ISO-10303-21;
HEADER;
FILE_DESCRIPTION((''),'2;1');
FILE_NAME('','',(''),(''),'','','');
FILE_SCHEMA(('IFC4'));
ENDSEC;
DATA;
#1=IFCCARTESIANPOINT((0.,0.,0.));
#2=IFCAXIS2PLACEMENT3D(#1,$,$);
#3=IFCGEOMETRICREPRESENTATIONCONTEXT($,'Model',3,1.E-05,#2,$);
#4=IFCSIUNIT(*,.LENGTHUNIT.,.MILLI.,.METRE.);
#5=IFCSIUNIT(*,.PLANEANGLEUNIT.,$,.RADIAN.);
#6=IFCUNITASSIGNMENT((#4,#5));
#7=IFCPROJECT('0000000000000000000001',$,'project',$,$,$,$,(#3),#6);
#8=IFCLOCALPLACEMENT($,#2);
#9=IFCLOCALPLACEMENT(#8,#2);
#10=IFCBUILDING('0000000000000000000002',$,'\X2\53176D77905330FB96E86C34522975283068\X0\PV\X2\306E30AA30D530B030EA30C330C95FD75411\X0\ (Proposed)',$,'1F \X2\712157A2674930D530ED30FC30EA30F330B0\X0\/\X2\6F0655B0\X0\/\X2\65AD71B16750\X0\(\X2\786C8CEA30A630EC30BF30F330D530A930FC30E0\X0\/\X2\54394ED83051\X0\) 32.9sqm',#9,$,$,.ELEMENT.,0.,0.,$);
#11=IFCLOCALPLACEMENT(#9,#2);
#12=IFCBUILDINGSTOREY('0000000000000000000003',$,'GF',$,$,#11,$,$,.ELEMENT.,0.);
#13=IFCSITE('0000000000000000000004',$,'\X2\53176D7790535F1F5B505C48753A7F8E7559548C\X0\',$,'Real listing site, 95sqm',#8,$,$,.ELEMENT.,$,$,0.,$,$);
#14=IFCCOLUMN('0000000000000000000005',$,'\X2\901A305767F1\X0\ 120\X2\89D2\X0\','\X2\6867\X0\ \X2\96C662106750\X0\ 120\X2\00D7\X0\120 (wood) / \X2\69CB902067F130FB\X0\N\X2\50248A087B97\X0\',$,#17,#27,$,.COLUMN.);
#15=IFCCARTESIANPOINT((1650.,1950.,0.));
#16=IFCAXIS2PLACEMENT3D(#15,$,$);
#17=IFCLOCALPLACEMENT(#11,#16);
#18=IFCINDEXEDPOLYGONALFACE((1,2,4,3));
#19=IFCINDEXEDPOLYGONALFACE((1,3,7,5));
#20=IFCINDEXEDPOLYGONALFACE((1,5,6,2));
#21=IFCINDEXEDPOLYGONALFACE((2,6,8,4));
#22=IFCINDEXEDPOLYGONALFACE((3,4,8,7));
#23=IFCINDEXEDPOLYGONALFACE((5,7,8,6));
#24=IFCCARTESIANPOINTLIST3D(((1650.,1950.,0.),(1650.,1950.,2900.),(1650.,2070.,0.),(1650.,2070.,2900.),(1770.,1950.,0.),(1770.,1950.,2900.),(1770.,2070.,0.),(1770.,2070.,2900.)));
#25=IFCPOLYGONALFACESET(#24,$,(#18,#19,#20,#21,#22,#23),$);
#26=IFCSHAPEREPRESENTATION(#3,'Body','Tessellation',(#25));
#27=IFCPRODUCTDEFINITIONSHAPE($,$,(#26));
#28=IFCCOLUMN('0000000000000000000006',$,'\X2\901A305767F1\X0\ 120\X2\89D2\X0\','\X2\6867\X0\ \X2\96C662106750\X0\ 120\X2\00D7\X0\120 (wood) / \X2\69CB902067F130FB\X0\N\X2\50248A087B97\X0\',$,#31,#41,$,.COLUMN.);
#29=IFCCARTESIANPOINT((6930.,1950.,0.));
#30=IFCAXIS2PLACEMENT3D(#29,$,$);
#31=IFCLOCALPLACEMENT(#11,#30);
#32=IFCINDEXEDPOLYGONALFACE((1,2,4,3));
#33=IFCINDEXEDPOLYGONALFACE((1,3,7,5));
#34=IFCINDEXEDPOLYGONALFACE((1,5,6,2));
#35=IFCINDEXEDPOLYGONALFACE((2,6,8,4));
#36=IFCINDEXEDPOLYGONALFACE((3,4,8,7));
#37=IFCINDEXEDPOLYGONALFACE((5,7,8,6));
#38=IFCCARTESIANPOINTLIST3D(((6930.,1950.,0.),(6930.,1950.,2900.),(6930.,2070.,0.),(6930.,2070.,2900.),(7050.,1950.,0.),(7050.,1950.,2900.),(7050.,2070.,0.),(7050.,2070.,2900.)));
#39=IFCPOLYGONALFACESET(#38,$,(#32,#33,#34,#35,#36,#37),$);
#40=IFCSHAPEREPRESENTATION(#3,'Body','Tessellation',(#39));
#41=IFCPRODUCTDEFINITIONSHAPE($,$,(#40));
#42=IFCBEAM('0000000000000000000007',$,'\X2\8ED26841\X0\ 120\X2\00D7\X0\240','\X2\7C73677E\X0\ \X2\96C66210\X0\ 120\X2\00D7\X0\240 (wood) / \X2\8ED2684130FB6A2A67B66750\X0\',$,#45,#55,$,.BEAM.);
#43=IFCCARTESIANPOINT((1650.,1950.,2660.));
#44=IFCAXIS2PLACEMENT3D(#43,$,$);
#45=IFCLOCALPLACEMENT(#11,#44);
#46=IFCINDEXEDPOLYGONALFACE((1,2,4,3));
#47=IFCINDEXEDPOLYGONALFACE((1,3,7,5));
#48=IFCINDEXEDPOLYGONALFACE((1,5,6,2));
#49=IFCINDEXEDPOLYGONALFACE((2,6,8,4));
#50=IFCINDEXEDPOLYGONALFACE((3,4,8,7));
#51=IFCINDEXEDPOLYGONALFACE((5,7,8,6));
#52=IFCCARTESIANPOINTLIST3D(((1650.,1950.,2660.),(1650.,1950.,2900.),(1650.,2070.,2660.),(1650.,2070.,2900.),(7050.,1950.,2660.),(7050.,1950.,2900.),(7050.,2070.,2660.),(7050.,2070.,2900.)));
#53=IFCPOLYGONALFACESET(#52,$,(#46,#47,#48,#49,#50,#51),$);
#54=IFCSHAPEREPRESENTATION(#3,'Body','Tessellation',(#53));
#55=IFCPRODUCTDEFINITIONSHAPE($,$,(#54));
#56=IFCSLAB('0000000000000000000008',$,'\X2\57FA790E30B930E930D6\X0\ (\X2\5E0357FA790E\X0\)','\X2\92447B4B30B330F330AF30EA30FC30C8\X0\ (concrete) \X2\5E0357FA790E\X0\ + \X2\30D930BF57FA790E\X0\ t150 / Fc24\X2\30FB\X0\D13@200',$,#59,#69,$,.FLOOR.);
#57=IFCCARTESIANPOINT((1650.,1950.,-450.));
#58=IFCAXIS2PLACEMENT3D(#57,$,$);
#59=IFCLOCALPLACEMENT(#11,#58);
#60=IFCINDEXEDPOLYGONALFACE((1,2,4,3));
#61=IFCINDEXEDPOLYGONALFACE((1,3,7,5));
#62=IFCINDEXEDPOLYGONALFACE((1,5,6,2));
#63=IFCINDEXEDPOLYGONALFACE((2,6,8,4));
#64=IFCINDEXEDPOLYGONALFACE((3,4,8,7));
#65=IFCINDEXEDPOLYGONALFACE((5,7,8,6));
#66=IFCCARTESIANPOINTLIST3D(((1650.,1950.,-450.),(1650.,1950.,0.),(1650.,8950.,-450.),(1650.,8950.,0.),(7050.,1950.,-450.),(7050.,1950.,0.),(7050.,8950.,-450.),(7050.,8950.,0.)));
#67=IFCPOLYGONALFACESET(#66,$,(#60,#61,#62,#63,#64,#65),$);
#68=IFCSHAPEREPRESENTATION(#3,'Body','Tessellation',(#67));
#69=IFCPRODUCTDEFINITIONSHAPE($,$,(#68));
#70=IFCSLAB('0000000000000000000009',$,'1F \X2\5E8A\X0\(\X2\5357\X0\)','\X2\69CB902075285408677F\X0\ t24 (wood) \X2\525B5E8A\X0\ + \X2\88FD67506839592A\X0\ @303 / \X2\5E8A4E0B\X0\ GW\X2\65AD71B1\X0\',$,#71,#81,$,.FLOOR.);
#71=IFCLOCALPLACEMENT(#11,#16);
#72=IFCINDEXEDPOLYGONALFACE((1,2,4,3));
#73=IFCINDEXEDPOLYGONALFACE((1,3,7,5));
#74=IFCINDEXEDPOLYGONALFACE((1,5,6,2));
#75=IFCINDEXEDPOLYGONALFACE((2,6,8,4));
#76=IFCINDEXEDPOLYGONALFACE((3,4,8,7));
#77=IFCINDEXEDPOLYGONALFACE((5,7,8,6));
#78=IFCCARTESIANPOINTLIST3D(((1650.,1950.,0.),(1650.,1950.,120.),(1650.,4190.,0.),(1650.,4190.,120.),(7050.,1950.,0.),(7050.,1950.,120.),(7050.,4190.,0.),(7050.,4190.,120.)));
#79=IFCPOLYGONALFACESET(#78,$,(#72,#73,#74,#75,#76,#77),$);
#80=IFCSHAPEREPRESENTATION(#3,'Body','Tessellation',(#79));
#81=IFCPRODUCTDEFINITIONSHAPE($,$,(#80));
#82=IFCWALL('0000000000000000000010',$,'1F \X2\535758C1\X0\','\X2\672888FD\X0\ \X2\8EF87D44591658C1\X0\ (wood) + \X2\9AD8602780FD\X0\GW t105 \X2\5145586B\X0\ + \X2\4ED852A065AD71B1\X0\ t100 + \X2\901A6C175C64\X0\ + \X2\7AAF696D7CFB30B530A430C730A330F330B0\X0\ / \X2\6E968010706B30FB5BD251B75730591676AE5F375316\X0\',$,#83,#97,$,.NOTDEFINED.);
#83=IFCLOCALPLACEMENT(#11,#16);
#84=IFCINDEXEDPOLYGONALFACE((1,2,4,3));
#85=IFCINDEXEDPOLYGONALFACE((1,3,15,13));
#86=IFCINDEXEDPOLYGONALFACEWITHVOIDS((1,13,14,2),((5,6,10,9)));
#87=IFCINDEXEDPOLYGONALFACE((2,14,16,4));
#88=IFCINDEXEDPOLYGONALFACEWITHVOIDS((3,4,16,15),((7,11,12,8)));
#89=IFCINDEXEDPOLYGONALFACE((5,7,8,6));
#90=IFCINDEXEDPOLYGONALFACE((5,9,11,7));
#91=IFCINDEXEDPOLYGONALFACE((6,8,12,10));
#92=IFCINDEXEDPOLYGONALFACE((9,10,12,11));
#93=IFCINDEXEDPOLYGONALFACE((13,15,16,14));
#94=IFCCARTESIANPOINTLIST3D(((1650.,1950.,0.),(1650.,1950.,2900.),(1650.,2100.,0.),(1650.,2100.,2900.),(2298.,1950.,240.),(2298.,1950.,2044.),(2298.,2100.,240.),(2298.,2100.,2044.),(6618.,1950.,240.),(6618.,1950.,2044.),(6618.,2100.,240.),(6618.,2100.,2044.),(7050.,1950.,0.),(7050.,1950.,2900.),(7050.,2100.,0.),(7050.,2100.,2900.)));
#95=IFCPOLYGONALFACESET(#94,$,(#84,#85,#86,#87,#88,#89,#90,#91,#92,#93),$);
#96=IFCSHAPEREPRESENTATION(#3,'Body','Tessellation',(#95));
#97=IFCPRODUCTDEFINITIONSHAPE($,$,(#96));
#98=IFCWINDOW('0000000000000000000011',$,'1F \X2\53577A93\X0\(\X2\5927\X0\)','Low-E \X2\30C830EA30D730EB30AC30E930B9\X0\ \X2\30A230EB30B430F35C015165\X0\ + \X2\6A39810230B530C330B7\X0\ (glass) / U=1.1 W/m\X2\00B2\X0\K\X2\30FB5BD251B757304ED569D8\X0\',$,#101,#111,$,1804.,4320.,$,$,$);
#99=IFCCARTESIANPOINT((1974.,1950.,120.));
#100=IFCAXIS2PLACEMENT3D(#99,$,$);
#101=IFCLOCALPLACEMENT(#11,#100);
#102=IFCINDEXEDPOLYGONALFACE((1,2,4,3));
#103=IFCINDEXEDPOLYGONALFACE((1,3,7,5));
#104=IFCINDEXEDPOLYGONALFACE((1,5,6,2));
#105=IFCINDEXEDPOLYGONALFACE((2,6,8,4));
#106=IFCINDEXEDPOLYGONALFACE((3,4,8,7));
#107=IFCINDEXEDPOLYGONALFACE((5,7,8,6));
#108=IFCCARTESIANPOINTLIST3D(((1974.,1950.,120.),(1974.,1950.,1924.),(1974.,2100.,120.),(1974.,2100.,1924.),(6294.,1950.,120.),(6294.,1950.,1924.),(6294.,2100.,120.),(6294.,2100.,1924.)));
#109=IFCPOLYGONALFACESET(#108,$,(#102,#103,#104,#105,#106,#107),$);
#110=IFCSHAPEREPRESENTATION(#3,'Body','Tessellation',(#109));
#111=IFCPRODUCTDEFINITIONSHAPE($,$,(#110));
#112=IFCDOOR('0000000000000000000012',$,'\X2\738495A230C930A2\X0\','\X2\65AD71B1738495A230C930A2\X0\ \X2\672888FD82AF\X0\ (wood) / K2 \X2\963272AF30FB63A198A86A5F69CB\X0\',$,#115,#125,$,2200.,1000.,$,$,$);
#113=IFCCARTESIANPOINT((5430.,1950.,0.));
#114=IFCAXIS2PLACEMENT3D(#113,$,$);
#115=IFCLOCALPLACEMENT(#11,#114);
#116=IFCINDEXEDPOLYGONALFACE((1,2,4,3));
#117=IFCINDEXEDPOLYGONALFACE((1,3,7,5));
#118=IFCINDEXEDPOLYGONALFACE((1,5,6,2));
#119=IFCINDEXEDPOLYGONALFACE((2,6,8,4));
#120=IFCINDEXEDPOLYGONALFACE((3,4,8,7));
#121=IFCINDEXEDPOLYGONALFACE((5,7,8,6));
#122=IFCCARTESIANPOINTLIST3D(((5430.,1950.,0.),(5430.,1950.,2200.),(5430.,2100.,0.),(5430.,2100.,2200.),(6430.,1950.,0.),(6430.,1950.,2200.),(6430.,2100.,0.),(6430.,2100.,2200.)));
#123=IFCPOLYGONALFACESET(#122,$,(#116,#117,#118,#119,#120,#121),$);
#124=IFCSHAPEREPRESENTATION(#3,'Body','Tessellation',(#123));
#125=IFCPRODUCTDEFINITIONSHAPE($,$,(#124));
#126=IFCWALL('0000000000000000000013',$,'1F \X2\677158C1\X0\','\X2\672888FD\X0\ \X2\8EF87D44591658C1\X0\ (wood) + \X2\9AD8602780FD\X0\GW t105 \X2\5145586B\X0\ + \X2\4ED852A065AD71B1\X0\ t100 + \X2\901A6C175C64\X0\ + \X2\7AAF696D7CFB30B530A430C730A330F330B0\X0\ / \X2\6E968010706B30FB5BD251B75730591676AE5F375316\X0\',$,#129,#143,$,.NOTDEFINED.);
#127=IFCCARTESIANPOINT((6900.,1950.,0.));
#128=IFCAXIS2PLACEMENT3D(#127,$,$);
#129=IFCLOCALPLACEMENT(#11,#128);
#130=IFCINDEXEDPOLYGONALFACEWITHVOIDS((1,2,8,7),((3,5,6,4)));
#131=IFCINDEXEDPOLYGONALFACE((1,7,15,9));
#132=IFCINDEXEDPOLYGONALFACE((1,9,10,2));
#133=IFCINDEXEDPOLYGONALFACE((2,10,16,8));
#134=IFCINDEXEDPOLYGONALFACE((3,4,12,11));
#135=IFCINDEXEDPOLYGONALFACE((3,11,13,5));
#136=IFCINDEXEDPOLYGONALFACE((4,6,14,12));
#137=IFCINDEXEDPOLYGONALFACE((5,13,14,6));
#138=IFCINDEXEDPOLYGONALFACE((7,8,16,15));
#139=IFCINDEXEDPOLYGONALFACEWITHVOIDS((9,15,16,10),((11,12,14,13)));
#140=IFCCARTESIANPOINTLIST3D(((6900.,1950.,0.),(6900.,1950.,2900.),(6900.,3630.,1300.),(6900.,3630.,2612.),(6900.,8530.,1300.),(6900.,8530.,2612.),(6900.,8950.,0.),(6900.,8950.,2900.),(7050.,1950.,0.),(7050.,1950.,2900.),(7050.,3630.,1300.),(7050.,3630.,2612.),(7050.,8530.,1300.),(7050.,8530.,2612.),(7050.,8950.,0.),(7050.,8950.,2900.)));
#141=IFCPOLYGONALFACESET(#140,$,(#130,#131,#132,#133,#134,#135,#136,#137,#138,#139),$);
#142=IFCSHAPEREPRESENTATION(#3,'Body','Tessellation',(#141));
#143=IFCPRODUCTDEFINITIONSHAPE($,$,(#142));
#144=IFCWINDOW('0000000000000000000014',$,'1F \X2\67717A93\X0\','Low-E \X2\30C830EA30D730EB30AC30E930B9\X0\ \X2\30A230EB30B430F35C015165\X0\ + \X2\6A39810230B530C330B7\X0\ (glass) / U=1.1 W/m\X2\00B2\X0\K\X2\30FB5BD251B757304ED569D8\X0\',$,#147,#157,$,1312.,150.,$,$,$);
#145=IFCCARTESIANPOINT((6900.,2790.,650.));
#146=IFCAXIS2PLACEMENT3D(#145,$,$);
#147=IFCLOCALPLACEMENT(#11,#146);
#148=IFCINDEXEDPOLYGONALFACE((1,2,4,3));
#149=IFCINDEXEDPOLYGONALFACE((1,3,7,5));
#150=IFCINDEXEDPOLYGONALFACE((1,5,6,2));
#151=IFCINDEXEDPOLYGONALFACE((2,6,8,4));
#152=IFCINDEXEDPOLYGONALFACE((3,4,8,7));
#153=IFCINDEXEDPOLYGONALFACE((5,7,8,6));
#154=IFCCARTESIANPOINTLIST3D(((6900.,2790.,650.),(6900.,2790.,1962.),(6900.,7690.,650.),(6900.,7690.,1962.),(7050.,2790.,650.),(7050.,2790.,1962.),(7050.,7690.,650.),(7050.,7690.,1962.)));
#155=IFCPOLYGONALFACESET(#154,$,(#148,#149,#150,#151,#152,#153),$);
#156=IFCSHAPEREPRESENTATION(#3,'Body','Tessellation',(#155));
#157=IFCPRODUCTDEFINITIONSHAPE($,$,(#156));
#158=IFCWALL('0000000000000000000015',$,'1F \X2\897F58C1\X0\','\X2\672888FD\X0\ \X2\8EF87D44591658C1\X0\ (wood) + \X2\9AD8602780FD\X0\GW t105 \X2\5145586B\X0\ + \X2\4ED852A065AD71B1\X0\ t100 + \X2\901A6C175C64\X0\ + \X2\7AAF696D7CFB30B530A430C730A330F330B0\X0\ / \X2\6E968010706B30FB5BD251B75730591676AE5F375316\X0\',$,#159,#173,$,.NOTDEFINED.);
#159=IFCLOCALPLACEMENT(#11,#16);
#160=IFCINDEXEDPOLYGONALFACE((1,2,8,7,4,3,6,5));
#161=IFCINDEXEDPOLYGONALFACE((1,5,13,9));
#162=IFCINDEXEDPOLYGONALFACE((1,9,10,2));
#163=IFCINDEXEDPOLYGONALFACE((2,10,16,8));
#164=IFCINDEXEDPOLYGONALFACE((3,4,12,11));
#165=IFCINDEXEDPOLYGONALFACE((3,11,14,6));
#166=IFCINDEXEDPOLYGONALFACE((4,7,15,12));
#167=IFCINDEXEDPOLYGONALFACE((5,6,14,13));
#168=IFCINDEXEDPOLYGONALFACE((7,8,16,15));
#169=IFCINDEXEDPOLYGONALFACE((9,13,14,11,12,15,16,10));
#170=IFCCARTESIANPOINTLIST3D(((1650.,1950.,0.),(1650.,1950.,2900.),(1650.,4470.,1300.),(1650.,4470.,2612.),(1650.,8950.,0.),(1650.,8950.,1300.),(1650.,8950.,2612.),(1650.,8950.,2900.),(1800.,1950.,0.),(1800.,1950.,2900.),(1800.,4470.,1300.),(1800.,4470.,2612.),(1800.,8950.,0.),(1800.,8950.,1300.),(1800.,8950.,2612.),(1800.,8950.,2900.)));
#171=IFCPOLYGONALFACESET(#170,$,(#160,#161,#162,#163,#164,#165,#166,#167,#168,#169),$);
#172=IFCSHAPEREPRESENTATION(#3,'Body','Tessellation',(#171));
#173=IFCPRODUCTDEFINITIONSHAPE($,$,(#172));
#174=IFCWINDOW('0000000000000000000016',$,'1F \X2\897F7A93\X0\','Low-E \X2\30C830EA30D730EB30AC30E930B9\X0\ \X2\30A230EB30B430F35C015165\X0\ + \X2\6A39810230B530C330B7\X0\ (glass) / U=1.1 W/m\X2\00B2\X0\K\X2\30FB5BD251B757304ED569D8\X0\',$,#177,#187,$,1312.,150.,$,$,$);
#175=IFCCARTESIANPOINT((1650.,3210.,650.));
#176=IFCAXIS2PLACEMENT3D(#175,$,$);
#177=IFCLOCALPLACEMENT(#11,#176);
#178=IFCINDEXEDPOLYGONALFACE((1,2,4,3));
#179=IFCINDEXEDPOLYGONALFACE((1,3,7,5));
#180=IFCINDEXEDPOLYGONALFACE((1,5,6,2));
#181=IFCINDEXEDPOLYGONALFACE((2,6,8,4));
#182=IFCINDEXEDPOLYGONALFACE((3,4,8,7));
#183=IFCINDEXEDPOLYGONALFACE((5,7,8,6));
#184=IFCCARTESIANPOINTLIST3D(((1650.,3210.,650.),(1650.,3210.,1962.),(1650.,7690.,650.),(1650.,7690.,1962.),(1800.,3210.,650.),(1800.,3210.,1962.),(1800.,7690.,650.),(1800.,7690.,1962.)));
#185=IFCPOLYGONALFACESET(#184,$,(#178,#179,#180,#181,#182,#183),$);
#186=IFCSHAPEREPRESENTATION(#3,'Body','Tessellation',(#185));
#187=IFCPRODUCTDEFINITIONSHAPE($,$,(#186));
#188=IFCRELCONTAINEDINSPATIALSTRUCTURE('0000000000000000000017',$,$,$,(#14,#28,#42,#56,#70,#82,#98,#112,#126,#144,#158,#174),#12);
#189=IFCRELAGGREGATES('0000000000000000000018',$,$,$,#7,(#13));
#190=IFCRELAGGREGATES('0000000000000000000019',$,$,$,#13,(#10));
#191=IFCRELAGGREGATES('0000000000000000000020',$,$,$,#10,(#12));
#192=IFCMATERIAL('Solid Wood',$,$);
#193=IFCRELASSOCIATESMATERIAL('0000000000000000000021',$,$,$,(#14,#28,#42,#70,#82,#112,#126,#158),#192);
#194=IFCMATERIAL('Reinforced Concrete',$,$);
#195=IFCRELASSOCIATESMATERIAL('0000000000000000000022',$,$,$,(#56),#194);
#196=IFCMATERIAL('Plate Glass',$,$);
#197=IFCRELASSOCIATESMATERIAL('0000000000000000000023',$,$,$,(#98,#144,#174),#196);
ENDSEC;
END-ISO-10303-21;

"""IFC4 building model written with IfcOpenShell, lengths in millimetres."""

from ifc_helpers import new_model, si_unit, frame, frame_2d, origin, place, context, project, spatial, rectangle, extrude, material, element, fill, save


model = new_model("IFC4")

# Units and contexts
model_context = context("Model", 3, precision=1e-05, world=origin())
ifc_project = project(units=[si_unit("LENGTHUNIT", "METRE", prefix="MILLI"), si_unit("PLANEANGLEUNIT", "RADIAN")], contexts=[model_context])

# Site, building, storey
site_placement = place(None, origin())
site = spatial("IfcSite", under=ifc_project, at=site_placement, Name="北海道弟子屈町美留和", ObjectType="Real listing site, 95sqm", CompositionType="ELEMENT", RefElevation=0.0)
building_placement = place(site_placement, origin())
building = spatial("IfcBuilding", under=site, at=building_placement, Name="北海道・雨水利用とPVのオフグリッド志向 (Proposed)", ObjectType="1F 無垢杉フローリング/漆喰/断熱材(硬質ウレタンフォーム/吹付け) 32.9sqm", CompositionType="ELEMENT", ElevationOfRefHeight=0.0, ElevationOfTerrain=0.0)
storey_placement = place(building_placement, origin())
storey = spatial("IfcBuildingStorey", under=building, at=storey_placement, Name="GF", CompositionType="ELEMENT", Elevation=0.0)

# Columns
ifc_material_1 = material(Name="Solid Wood")
column_1_placement = place(storey_placement, frame((1650.0, 1950.0, 0.0)))
element("IfcColumn", 1, at=column_1_placement, inside=storey, material=ifc_material_1, Name="通し柱 120角", Description="桧 集成材 120×120 (wood) / 構造柱・N値計算", PredefinedType="COLUMN", context=model_context, shape_type="SweptSolid", body=[
    extrude(rectangle(XDim=120.0, YDim=120.0, at=frame_2d((60.0, 60.0))), frame((1650.0, 1950.0, 0.0)), (0.0, 0.0, 1.0), 2900.0),
])
column_2_placement = place(storey_placement, frame((6930.0, 1950.0, 0.0)))
element("IfcColumn", 2, at=column_2_placement, inside=storey, material=ifc_material_1, Name="通し柱 120角", Description="桧 集成材 120×120 (wood) / 構造柱・N値計算", PredefinedType="COLUMN", context=model_context, shape_type="SweptSolid", body=[
    extrude(rectangle(XDim=120.0, YDim=120.0, at=frame_2d((60.0, 60.0))), frame((6930.0, 1950.0, 0.0)), (0.0, 0.0, 1.0), 2900.0),
])

# Beam
beam_1_placement = place(storey_placement, frame((1650.0, 1950.0, 2660.0)))
element("IfcBeam", 3, at=beam_1_placement, inside=storey, material=ifc_material_1, Name="軒桁 120×240", Description="米松 集成 120×240 (wood) / 軒桁・横架材", PredefinedType="BEAM", context=model_context, shape_type="SweptSolid", body=[
    extrude(rectangle(XDim=5400.0, YDim=120.0, at=frame_2d((2700.0, 60.0))), frame((1650.0, 1950.0, 2660.0)), (0.0, 0.0, 1.0), 240.0),
])

# Slabs
ifc_material_2 = material(Name="Reinforced Concrete")
slab_1_placement = place(storey_placement, frame((1650.0, 1950.0, -450.0)))
element("IfcSlab", 4, at=slab_1_placement, inside=storey, material=ifc_material_2, Name="基礎スラブ (布基礎)", Description="鉄筋コンクリート (concrete) 布基礎 + ベタ基礎 t150 / Fc24・D13@200", PredefinedType="FLOOR", context=model_context, shape_type="SweptSolid", body=[
    extrude(rectangle(XDim=5400.0, YDim=7000.0, at=frame_2d((2700.0, 3500.0))), frame((1650.0, 1950.0, -450.0)), (0.0, 0.0, 1.0), 450.0),
])
slab_2_placement = place(storey_placement, frame((1650.0, 1950.0, 0.0)))
element("IfcSlab", 5, at=slab_2_placement, inside=storey, material=ifc_material_1, Name="1F 床(南)", Description="構造用合板 t24 (wood) 剛床 + 製材根太 @303 / 床下 GW断熱", PredefinedType="FLOOR", context=model_context, shape_type="SweptSolid", body=[
    extrude(rectangle(XDim=5400.0, YDim=2240.0, at=frame_2d((2700.0, 1120.0))), frame((1650.0, 1950.0, 0.0)), (0.0, 0.0, 1.0), 120.0),
])

# Wall, openings, window, door
wall_1_placement = place(storey_placement, frame((1650.0, 1950.0, 0.0)))
wall_1 = element("IfcWall", 6, at=wall_1_placement, inside=storey, material=ifc_material_1, Name="1F 南壁", Description="木製 軸組外壁 (wood) + 高性能GW t105 充填 + 付加断熱 t100 + 通気層 + 窯業系サイディング / 準耐火・寒冷地外皮強化", PredefinedType="NOTDEFINED", context=model_context, shape_type="SweptSolid", body=[
    extrude(rectangle(XDim=5400.0, YDim=150.0, at=frame_2d((2700.0, 75.0))), frame((1650.0, 1950.0, 0.0)), (0.0, 0.0, 1.0), 2900.0),
])
opening_1_placement = place(storey_placement, frame((1974.0, 1950.0, 120.0)))
opening_1 = element("IfcOpeningElement", 7, at=opening_1_placement, cuts=wall_1, PredefinedType="NOTDEFINED", context=model_context, shape_type="SweptSolid", body=[
    extrude(rectangle(XDim=4320.0, YDim=150.0, at=frame_2d((2160.0, 75.0))), frame((1974.0, 1950.0, 120.0)), (0.0, 0.0, 1.0), 1804.0),
])
opening_2_placement = place(storey_placement, frame((5430.0, 1950.0, 0.0)))
opening_2 = element("IfcOpeningElement", 8, at=opening_2_placement, cuts=wall_1, PredefinedType="NOTDEFINED", context=model_context, shape_type="SweptSolid", body=[
    extrude(rectangle(XDim=1000.0, YDim=150.0, at=frame_2d((500.0, 75.0))), frame((5430.0, 1950.0, 0.0)), (0.0, 0.0, 1.0), 2200.0),
])
ifc_material_3 = material(Name="Plate Glass")
window_1_placement = place(storey_placement, frame((1974.0, 1950.0, 120.0)))
window_1 = element("IfcWindow", 9, at=window_1_placement, inside=storey, material=ifc_material_3, Name="1F 南窓(大)", Description="Low-E トリプルガラス アルゴン封入 + 樹脂サッシ (glass) / U=1.1 W/m²K・寒冷地仕様", OverallHeight=1804.0, OverallWidth=4320.0, context=model_context, shape_type="SweptSolid", body=[
    extrude(rectangle(XDim=4320.0, YDim=150.0, at=frame_2d((2160.0, 75.0))), frame((1974.0, 1950.0, 120.0)), (0.0, 0.0, 1.0), 1804.0),
])
fill(opening_1, window_1)
door_placement = place(storey_placement, frame((5430.0, 1950.0, 0.0)))
door = element("IfcDoor", 10, at=door_placement, inside=storey, material=ifc_material_1, Name="玄関ドア", Description="断熱玄関ドア 木製芯 (wood) / K2 防犯・採風機構", OverallHeight=2200.0, OverallWidth=1000.0, context=model_context, shape_type="SweptSolid", body=[
    extrude(rectangle(XDim=1000.0, YDim=150.0, at=frame_2d((500.0, 75.0))), frame((5430.0, 1950.0, 0.0)), (0.0, 0.0, 1.0), 2200.0),
])
fill(opening_2, door)

# Walls, openings, windows
wall_2_placement = place(storey_placement, frame((6900.0, 1950.0, 0.0)))
wall_2 = element("IfcWall", 11, at=wall_2_placement, inside=storey, material=ifc_material_1, Name="1F 東壁", Description="木製 軸組外壁 (wood) + 高性能GW t105 充填 + 付加断熱 t100 + 通気層 + 窯業系サイディング / 準耐火・寒冷地外皮強化", PredefinedType="NOTDEFINED", context=model_context, shape_type="SweptSolid", body=[
    extrude(rectangle(XDim=150.0, YDim=7000.0, at=frame_2d((75.0, 3500.0))), frame((6900.0, 1950.0, 0.0)), (0.0, 0.0, 1.0), 2900.0),
])
opening_3_placement = place(storey_placement, frame((6900.0, 2790.0, 650.0)))
opening_3 = element("IfcOpeningElement", 12, at=opening_3_placement, cuts=wall_2, PredefinedType="NOTDEFINED", context=model_context, shape_type="SweptSolid", body=[
    extrude(rectangle(XDim=150.0, YDim=4900.0, at=frame_2d((75.0, 2450.0))), frame((6900.0, 2790.0, 650.0)), (0.0, 0.0, 1.0), 1312.0),
])
window_2_placement = place(storey_placement, frame((6900.0, 2790.0, 650.0)))
window_2 = element("IfcWindow", 13, at=window_2_placement, inside=storey, material=ifc_material_3, Name="1F 東窓", Description="Low-E トリプルガラス アルゴン封入 + 樹脂サッシ (glass) / U=1.1 W/m²K・寒冷地仕様", OverallHeight=1312.0, OverallWidth=150.0, context=model_context, shape_type="SweptSolid", body=[
    extrude(rectangle(XDim=150.0, YDim=4900.0, at=frame_2d((75.0, 2450.0))), frame((6900.0, 2790.0, 650.0)), (0.0, 0.0, 1.0), 1312.0),
])
fill(opening_3, window_2)
wall_3_placement = place(storey_placement, frame((1650.0, 1950.0, 0.0)))
wall_3 = element("IfcWall", 14, at=wall_3_placement, inside=storey, material=ifc_material_1, Name="1F 西壁", Description="木製 軸組外壁 (wood) + 高性能GW t105 充填 + 付加断熱 t100 + 通気層 + 窯業系サイディング / 準耐火・寒冷地外皮強化", PredefinedType="NOTDEFINED", context=model_context, shape_type="SweptSolid", body=[
    extrude(rectangle(XDim=150.0, YDim=7000.0, at=frame_2d((75.0, 3500.0))), frame((1650.0, 1950.0, 0.0)), (0.0, 0.0, 1.0), 2900.0),
])
opening_4_placement = place(storey_placement, frame((1650.0, 3210.0, 650.0)))
opening_4 = element("IfcOpeningElement", 15, at=opening_4_placement, cuts=wall_3, PredefinedType="NOTDEFINED", context=model_context, shape_type="SweptSolid", body=[
    extrude(rectangle(XDim=150.0, YDim=4480.0, at=frame_2d((75.0, 2240.0))), frame((1650.0, 3210.0, 650.0)), (0.0, 0.0, 1.0), 1312.0),
])
window_3_placement = place(storey_placement, frame((1650.0, 3210.0, 650.0)))
window_3 = element("IfcWindow", 16, at=window_3_placement, inside=storey, material=ifc_material_3, Name="1F 西窓", Description="Low-E トリプルガラス アルゴン封入 + 樹脂サッシ (glass) / U=1.1 W/m²K・寒冷地仕様", OverallHeight=1312.0, OverallWidth=150.0, context=model_context, shape_type="SweptSolid", body=[
    extrude(rectangle(XDim=150.0, YDim=4480.0, at=frame_2d((75.0, 2240.0))), frame((1650.0, 3210.0, 650.0)), (0.0, 0.0, 1.0), 1312.0),
])
fill(opening_4, window_3)

save(model, "model.ifc")
